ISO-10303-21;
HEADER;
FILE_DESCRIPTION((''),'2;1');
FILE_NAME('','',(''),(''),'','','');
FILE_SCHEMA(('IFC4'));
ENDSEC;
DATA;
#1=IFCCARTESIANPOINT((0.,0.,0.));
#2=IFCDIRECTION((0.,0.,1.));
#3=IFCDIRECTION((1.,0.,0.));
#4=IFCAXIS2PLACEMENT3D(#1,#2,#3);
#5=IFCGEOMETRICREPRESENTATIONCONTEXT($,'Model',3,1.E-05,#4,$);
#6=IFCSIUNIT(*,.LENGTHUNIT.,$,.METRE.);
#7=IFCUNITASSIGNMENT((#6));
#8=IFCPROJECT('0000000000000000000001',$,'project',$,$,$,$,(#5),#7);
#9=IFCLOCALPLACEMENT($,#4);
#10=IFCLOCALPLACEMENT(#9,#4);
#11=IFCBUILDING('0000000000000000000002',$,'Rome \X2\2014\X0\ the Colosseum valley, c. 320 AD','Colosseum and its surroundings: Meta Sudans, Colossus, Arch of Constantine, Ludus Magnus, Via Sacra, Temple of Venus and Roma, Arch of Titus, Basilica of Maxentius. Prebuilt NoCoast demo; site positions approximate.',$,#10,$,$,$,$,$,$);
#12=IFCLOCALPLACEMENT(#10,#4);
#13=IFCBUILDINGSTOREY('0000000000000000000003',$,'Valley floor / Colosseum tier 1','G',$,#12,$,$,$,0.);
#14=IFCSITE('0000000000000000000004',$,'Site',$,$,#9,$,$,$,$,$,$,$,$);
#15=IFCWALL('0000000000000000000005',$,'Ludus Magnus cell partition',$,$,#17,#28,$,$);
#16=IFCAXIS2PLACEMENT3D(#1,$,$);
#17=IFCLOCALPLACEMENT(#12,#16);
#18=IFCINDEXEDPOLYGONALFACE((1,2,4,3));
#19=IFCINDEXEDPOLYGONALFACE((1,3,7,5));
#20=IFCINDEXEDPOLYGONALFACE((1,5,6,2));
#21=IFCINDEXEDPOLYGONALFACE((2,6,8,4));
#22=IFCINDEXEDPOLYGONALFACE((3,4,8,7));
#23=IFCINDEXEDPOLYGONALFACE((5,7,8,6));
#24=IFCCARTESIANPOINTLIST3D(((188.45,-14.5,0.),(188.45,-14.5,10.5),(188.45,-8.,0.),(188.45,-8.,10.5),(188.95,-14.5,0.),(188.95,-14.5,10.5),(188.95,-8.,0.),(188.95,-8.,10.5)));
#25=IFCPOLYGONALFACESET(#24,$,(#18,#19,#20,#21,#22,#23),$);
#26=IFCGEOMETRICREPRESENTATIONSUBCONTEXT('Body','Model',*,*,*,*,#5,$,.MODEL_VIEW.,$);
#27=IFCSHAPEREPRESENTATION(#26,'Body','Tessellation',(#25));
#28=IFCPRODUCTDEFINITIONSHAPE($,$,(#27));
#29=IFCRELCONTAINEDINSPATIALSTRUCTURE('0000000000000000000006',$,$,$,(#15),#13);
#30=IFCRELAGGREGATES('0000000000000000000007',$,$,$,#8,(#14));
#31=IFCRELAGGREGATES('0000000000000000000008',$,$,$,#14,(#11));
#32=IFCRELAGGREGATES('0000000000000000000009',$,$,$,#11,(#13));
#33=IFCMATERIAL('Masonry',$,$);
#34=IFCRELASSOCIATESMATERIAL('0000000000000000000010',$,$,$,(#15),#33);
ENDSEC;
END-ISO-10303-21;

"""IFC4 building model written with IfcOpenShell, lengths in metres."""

from ifc_helpers import new_model, si_unit, frame, origin_with_axes, place, context, subcontext, project, spatial, indexed_curve, outline, extrude, material, element, save


model = new_model("IFC4")

# Units and contexts
model_context = context("Model", 3, precision=1e-05, world=origin_with_axes())
body_context = subcontext(model_context, "Body", "Model", "MODEL_VIEW")
ifc_project = project(units=[si_unit("LENGTHUNIT", "METRE")], contexts=[model_context])

# Site, building, storey
site_placement = place(None, origin_with_axes())
site = spatial("IfcSite", under=ifc_project, at=site_placement, Name="Site")
building_placement = place(site_placement, origin_with_axes())
building = spatial("IfcBuilding", under=site, at=building_placement, Name="Rome — the Colosseum valley, c. 320 AD", Description="Colosseum and its surroundings: Meta Sudans, Colossus, Arch of Constantine, Ludus Magnus, Via Sacra, Temple of Venus and Roma, Arch of Titus, Basilica of Maxentius. Prebuilt NoCoast demo; site positions approximate.")
storey_placement = place(building_placement, origin_with_axes())
storey = spatial("IfcBuildingStorey", under=building, at=storey_placement, Name="Valley floor / Colosseum tier 1", Description="G", Elevation=0.0)

# Shared definitions
ifc_material_1 = material(Name="Masonry")

# Wall
wall_1_placement = place(storey_placement, frame((188.7, -8.0, 0.0), z_axis=(0.0, 0.0, 1.0), x_axis=(0.0, -1.0, 0.0)))
element("IfcWall", 1, at=wall_1_placement, inside=storey, material=ifc_material_1, Name="Ludus Magnus cell partition", context=body_context, shape_type="SweptSolid", body=[
    extrude(outline(indexed_curve([(0.0, 0.0), (0.0, 0.5), (6.5, 0.5), (6.5, 0.0), (0.0, 0.0)], self_intersect=False)), frame((0.0, -0.25, 0.0), z_axis=(0.0, 0.0, 1.0), x_axis=(1.0, 0.0, 0.0)), (0.0, 0.0, 1.0), 10.5),
])

save(model, "model.ifc")
